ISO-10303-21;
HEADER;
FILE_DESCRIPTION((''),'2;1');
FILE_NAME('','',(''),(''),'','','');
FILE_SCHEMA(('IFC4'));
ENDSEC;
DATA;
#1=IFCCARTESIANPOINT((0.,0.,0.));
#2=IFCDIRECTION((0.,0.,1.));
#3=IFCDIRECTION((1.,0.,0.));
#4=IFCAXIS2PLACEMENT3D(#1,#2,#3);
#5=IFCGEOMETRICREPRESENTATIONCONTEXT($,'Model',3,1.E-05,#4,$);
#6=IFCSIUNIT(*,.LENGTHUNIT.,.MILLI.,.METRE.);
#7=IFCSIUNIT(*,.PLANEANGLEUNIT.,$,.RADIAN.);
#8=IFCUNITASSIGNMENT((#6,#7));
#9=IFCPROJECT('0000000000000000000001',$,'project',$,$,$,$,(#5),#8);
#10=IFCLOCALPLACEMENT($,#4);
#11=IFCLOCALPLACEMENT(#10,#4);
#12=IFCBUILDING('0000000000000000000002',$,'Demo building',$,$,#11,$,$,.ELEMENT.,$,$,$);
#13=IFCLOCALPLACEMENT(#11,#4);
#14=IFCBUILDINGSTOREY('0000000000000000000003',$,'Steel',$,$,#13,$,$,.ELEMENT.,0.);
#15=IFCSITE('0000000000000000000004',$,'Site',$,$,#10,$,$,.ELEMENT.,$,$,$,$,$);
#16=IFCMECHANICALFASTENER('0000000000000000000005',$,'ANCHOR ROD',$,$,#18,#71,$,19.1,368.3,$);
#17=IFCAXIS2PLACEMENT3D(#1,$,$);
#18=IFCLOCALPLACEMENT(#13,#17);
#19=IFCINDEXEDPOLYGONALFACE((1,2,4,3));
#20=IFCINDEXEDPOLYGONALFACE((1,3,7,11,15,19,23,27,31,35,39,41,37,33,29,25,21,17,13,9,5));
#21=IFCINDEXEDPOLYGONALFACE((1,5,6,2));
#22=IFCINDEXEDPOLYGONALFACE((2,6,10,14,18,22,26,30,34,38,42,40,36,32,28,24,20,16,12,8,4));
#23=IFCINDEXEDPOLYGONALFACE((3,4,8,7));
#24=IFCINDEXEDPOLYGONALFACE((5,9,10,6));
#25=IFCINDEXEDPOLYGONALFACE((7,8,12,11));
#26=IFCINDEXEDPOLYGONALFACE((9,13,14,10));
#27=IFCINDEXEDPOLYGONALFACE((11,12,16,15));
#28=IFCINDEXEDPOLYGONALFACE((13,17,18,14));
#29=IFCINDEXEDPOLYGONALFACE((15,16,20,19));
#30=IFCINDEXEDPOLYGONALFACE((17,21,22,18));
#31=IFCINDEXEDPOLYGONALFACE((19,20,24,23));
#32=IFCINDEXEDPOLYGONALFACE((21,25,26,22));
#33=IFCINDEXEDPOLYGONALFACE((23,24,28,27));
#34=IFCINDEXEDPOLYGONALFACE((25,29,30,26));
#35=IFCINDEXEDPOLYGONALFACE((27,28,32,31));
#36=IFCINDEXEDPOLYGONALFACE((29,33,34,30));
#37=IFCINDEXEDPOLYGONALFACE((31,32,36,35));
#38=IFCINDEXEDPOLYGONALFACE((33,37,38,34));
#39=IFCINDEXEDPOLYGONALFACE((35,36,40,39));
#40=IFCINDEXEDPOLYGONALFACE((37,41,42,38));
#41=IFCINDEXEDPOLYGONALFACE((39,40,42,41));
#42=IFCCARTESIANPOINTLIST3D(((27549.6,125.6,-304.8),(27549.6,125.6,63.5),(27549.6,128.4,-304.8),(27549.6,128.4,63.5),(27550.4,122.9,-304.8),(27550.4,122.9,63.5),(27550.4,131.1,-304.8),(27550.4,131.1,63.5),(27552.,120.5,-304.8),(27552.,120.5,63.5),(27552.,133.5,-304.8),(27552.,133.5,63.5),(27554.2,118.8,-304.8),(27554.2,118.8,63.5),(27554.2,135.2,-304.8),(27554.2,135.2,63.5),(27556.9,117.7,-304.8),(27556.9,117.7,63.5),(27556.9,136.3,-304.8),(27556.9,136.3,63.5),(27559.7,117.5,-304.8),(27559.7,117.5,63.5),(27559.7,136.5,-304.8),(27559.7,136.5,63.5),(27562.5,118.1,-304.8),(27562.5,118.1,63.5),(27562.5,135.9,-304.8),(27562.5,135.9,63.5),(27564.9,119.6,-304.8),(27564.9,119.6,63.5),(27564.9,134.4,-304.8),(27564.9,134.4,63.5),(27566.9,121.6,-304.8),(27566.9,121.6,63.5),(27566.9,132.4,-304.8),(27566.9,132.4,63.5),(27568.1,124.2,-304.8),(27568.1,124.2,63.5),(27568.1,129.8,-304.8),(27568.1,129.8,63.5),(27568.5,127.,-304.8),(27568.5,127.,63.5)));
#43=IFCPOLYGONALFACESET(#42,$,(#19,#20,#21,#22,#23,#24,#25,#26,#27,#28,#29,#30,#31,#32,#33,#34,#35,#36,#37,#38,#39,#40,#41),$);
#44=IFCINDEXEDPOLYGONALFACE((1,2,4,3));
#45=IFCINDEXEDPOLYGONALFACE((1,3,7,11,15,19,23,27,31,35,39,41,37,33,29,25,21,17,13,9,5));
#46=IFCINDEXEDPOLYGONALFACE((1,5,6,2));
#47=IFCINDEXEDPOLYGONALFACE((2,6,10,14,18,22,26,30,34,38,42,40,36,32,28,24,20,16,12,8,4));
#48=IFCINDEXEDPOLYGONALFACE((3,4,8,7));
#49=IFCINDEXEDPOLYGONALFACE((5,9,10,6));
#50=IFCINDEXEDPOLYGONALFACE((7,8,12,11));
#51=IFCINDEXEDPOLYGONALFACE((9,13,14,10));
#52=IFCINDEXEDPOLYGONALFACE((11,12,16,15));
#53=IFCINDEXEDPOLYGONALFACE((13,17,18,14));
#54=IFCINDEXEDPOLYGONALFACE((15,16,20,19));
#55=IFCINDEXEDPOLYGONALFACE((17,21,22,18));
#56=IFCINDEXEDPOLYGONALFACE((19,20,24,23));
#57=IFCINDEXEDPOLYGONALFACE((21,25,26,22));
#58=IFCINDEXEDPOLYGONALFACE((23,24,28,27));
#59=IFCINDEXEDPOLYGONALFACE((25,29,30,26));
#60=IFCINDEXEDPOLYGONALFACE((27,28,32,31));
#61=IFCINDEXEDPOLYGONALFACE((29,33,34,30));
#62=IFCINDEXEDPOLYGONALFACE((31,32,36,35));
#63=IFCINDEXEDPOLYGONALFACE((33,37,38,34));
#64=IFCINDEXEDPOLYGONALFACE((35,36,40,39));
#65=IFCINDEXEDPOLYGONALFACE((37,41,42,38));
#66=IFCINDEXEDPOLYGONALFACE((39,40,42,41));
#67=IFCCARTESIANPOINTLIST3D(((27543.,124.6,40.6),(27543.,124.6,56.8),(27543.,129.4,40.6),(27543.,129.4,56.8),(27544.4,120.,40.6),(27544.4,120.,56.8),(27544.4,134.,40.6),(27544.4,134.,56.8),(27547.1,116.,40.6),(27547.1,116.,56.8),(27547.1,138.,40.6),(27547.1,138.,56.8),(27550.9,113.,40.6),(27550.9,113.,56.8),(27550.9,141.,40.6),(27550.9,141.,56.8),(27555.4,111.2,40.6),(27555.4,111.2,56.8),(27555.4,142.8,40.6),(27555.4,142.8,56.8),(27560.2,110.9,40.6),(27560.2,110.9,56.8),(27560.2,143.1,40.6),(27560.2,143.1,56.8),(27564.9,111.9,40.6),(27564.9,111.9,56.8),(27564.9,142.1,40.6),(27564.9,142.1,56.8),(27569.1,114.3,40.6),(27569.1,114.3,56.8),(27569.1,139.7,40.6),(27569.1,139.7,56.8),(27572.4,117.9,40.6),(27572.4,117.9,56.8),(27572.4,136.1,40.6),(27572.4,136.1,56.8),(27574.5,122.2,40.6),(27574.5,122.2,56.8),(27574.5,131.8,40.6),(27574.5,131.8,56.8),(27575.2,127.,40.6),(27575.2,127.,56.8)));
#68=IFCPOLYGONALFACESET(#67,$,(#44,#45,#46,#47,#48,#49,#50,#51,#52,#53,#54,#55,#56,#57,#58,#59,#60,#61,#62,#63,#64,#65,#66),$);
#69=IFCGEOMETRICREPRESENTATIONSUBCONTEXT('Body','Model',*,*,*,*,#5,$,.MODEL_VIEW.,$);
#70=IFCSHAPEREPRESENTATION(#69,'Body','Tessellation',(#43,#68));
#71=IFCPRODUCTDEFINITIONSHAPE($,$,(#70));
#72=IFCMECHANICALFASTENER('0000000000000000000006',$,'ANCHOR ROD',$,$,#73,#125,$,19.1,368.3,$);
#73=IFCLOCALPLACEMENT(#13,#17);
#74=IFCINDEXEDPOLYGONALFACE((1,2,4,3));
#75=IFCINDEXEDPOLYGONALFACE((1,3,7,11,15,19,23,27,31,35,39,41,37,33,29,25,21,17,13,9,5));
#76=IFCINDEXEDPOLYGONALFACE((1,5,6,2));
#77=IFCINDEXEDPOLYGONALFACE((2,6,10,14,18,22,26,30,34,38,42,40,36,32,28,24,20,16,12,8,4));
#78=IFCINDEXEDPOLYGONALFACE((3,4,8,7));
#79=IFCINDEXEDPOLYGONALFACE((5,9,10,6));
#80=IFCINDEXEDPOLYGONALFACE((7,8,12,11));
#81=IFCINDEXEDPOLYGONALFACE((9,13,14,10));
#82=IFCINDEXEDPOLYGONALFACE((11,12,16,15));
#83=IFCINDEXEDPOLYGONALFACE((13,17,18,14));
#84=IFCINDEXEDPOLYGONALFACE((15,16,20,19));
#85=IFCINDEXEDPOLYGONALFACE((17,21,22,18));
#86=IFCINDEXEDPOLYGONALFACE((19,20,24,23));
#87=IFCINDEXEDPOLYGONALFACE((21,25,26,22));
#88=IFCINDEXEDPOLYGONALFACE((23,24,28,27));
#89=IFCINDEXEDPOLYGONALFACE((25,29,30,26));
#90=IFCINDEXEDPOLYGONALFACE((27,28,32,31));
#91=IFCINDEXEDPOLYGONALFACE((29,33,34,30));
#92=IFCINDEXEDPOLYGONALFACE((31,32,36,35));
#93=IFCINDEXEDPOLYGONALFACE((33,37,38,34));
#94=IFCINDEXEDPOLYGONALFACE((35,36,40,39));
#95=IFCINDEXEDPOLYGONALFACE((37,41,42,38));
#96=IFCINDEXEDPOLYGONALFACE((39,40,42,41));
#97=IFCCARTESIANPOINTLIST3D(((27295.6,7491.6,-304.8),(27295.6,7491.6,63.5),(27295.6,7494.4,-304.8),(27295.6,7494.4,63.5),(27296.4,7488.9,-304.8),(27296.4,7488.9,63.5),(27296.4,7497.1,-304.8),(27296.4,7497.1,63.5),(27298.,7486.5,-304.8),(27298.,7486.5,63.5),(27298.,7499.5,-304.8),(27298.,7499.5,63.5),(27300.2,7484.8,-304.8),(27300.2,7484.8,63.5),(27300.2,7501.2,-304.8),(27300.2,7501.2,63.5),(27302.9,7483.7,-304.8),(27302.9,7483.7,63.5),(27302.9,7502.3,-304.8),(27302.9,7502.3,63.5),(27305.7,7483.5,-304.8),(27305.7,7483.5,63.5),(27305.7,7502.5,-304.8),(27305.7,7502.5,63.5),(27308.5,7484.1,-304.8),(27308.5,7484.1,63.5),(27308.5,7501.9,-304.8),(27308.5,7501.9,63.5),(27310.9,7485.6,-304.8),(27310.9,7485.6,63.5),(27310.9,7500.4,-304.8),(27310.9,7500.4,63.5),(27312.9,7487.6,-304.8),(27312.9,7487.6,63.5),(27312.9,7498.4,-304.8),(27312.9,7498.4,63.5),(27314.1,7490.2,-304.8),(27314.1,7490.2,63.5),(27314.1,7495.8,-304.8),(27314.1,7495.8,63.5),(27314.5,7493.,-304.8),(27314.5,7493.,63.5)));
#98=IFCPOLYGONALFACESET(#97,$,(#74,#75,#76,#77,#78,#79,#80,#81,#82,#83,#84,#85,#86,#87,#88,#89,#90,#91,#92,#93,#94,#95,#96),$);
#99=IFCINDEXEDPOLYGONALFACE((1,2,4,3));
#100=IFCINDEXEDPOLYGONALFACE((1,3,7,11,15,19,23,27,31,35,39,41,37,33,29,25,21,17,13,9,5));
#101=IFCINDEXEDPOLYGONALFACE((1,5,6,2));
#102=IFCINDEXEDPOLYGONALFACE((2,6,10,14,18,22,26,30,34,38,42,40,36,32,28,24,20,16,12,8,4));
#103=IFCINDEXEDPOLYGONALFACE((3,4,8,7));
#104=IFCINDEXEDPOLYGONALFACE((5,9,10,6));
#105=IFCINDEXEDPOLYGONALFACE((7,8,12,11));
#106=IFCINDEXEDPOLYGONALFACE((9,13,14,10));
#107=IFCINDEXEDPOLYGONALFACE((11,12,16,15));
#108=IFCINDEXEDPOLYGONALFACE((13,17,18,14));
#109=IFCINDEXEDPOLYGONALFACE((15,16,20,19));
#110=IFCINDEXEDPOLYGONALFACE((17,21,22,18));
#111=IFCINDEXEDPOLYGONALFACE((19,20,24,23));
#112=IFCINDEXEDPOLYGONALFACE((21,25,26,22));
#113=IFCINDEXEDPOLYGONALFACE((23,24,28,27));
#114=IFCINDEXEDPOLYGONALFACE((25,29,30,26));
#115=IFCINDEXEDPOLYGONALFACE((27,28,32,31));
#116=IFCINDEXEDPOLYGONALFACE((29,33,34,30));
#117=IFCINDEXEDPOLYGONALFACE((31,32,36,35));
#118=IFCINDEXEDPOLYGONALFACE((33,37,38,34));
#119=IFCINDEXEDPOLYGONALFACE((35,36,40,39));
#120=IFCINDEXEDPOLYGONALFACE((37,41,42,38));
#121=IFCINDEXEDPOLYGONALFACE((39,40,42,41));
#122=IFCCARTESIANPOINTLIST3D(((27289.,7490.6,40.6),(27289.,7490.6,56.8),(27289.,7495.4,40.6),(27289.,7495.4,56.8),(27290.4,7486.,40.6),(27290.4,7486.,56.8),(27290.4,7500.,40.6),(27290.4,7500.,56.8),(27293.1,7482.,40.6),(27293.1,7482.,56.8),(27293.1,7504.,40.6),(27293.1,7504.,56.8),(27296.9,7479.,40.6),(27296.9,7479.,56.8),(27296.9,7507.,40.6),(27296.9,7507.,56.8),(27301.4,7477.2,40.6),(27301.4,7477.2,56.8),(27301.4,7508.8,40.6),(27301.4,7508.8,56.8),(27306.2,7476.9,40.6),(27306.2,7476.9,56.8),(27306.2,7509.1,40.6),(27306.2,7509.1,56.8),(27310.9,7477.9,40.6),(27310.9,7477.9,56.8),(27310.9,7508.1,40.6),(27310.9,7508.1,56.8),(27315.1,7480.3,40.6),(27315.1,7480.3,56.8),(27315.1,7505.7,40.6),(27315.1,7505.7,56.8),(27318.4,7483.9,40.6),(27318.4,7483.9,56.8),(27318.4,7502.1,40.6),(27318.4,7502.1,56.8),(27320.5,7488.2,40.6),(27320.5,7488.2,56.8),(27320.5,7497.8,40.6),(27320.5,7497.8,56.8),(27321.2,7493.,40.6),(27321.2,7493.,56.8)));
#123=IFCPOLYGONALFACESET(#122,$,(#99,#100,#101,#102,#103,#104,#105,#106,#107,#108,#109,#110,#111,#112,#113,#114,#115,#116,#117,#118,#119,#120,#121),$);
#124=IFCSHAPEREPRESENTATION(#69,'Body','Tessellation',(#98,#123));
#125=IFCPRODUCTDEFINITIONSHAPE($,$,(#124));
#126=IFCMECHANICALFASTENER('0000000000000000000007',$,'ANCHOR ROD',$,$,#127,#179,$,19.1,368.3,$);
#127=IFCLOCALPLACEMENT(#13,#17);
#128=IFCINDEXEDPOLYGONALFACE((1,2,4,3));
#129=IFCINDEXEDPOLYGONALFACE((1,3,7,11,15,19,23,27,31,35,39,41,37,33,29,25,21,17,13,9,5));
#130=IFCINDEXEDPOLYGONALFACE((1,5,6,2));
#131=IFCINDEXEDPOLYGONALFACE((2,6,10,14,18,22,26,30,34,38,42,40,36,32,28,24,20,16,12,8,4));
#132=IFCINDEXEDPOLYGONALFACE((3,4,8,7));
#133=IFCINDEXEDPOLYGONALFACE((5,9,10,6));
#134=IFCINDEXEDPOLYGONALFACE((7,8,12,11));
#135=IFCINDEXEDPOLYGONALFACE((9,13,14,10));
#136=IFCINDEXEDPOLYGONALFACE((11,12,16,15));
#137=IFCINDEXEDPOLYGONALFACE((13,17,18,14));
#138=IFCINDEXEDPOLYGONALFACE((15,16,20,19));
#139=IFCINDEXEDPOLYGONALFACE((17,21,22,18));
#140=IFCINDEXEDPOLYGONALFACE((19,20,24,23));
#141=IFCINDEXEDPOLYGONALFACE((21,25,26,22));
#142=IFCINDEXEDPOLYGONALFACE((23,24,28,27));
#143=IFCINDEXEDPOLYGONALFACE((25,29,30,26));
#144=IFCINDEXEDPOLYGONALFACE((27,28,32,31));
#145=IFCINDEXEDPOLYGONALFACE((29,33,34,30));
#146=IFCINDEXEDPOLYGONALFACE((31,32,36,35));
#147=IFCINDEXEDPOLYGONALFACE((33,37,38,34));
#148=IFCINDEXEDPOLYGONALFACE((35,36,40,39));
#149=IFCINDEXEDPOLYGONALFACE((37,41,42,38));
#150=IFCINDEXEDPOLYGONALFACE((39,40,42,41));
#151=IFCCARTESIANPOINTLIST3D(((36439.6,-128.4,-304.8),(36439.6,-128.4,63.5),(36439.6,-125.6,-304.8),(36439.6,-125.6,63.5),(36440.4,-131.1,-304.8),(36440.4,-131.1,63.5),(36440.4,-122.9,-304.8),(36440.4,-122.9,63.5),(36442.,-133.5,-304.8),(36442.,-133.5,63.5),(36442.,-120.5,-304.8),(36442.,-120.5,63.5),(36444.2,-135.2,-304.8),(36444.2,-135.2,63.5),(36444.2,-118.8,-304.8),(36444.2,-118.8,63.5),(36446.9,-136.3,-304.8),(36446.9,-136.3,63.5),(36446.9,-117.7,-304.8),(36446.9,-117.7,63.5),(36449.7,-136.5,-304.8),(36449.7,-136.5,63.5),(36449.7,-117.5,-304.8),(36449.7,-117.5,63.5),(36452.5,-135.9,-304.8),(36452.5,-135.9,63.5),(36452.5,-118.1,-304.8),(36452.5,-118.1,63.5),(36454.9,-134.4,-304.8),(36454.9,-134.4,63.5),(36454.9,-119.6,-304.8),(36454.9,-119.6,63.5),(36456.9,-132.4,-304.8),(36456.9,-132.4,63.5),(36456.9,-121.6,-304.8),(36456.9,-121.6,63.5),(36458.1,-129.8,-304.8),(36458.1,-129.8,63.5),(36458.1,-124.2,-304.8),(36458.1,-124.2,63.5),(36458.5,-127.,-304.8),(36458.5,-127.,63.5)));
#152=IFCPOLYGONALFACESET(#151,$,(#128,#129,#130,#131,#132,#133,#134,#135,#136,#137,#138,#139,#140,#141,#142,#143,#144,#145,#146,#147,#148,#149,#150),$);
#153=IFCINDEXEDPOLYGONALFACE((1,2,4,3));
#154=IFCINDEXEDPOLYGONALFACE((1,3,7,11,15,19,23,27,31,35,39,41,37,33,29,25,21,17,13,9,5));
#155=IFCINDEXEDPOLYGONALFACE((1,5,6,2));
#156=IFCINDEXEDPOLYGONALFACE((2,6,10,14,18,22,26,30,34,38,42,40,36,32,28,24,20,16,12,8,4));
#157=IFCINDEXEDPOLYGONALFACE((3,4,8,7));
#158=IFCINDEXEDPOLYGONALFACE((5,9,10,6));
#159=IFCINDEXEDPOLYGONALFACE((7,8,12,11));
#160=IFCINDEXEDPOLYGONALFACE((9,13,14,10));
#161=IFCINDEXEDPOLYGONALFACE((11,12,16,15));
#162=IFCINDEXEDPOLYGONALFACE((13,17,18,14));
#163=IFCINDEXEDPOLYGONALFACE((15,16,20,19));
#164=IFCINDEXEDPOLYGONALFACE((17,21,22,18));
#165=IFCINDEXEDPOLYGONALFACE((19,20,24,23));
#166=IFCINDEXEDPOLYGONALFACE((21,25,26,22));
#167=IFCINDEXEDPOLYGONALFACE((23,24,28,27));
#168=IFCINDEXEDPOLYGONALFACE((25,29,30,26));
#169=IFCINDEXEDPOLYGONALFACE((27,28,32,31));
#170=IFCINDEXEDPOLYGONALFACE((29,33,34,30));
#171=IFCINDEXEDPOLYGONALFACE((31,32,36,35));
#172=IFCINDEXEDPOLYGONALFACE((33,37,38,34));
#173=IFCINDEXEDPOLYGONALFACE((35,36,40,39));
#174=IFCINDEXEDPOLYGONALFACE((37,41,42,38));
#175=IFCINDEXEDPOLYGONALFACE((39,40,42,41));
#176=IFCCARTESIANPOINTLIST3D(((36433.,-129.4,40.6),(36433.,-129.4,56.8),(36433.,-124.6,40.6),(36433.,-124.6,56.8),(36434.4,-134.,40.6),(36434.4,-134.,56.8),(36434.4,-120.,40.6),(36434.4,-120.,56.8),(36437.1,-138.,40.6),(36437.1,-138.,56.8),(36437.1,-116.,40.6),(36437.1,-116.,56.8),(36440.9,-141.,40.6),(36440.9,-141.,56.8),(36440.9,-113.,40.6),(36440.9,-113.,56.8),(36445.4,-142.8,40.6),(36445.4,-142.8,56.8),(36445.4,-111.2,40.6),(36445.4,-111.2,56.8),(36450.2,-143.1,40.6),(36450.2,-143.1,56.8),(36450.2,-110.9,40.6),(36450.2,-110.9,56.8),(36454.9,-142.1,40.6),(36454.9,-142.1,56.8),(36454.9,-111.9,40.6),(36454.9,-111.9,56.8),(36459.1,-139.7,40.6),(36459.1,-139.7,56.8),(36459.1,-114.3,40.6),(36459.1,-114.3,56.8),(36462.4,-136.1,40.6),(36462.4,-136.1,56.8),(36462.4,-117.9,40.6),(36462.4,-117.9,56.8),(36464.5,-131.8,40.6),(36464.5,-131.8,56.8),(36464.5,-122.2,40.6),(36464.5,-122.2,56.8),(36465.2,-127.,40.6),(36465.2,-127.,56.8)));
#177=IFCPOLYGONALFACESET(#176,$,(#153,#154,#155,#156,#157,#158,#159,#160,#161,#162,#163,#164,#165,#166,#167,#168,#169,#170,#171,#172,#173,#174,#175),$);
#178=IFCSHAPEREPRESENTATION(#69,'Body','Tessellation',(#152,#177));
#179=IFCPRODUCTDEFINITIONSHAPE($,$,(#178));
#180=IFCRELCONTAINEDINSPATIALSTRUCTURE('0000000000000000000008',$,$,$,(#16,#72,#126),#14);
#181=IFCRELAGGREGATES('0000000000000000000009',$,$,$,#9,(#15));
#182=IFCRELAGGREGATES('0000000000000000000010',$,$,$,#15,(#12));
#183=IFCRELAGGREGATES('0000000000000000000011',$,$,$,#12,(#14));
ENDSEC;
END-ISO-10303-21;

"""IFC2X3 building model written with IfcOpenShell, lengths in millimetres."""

from ifc_helpers import new_model, si_unit, frame, origin, origin_with_axes, origin_2d, place, context, subcontext, project, spatial, circle, extrude, element, save


model = new_model("IFC2X3")

# Units and contexts
model_context = context("Model", 3, precision=1e-05, world=origin_with_axes())
body_context = subcontext(model_context, "Body", "Model", "MODEL_VIEW")
ifc_project = project(units=[si_unit("LENGTHUNIT", "METRE", prefix="MILLI"), si_unit("PLANEANGLEUNIT", "RADIAN")], contexts=[model_context])

# Site, building, storey
site_placement = place(None, origin_with_axes())
site = spatial("IfcSite", under=ifc_project, at=site_placement, Name="Site", CompositionType="ELEMENT")
building_placement = place(site_placement, origin_with_axes())
building = spatial("IfcBuilding", under=site, at=building_placement, Name="Demo building", CompositionType="ELEMENT")
placement = place(building_placement, origin_with_axes())
storey = spatial("IfcBuildingStorey", under=building, at=placement, Name="Steel", CompositionType="ELEMENT", Elevation=0.0)

# Mechanical fasteners
for number, where, z_axis, x_axis, name in (
    (1, (27559.0, 127.0, -304.8), (0.0, 0.0, 1.0), (1.0, 0.0, 0.0), "ANCHOR ROD"),
    (2, (27305.0, 7493.0, -304.8), (0.0, 0.0, 1.0), (1.0, 0.0, 0.0), "ANCHOR ROD"),
    (3, (36449.0, -127.0, -304.8), (0.0, 0.0, 1.0), (1.0, 0.0, 0.0), "ANCHOR ROD"),
):
    element("IfcMechanicalFastener", number, at=place(placement, frame(where, z_axis=z_axis, x_axis=x_axis)), inside=storey, Name=name, NominalDiameter=19.1, NominalLength=368.3, context=body_context, shape_type="SweptSolid", body=[
        extrude(circle(Radius=9.5, at=origin_2d()), origin(), (0.0, 0.0, 1.0), 368.3),
        extrude(circle(Radius=16.2, at=origin_2d()), frame((0.0, 0.0, 345.4)), (0.0, 0.0, 1.0), 16.2),
    ])

save(model, "model.ifc")
